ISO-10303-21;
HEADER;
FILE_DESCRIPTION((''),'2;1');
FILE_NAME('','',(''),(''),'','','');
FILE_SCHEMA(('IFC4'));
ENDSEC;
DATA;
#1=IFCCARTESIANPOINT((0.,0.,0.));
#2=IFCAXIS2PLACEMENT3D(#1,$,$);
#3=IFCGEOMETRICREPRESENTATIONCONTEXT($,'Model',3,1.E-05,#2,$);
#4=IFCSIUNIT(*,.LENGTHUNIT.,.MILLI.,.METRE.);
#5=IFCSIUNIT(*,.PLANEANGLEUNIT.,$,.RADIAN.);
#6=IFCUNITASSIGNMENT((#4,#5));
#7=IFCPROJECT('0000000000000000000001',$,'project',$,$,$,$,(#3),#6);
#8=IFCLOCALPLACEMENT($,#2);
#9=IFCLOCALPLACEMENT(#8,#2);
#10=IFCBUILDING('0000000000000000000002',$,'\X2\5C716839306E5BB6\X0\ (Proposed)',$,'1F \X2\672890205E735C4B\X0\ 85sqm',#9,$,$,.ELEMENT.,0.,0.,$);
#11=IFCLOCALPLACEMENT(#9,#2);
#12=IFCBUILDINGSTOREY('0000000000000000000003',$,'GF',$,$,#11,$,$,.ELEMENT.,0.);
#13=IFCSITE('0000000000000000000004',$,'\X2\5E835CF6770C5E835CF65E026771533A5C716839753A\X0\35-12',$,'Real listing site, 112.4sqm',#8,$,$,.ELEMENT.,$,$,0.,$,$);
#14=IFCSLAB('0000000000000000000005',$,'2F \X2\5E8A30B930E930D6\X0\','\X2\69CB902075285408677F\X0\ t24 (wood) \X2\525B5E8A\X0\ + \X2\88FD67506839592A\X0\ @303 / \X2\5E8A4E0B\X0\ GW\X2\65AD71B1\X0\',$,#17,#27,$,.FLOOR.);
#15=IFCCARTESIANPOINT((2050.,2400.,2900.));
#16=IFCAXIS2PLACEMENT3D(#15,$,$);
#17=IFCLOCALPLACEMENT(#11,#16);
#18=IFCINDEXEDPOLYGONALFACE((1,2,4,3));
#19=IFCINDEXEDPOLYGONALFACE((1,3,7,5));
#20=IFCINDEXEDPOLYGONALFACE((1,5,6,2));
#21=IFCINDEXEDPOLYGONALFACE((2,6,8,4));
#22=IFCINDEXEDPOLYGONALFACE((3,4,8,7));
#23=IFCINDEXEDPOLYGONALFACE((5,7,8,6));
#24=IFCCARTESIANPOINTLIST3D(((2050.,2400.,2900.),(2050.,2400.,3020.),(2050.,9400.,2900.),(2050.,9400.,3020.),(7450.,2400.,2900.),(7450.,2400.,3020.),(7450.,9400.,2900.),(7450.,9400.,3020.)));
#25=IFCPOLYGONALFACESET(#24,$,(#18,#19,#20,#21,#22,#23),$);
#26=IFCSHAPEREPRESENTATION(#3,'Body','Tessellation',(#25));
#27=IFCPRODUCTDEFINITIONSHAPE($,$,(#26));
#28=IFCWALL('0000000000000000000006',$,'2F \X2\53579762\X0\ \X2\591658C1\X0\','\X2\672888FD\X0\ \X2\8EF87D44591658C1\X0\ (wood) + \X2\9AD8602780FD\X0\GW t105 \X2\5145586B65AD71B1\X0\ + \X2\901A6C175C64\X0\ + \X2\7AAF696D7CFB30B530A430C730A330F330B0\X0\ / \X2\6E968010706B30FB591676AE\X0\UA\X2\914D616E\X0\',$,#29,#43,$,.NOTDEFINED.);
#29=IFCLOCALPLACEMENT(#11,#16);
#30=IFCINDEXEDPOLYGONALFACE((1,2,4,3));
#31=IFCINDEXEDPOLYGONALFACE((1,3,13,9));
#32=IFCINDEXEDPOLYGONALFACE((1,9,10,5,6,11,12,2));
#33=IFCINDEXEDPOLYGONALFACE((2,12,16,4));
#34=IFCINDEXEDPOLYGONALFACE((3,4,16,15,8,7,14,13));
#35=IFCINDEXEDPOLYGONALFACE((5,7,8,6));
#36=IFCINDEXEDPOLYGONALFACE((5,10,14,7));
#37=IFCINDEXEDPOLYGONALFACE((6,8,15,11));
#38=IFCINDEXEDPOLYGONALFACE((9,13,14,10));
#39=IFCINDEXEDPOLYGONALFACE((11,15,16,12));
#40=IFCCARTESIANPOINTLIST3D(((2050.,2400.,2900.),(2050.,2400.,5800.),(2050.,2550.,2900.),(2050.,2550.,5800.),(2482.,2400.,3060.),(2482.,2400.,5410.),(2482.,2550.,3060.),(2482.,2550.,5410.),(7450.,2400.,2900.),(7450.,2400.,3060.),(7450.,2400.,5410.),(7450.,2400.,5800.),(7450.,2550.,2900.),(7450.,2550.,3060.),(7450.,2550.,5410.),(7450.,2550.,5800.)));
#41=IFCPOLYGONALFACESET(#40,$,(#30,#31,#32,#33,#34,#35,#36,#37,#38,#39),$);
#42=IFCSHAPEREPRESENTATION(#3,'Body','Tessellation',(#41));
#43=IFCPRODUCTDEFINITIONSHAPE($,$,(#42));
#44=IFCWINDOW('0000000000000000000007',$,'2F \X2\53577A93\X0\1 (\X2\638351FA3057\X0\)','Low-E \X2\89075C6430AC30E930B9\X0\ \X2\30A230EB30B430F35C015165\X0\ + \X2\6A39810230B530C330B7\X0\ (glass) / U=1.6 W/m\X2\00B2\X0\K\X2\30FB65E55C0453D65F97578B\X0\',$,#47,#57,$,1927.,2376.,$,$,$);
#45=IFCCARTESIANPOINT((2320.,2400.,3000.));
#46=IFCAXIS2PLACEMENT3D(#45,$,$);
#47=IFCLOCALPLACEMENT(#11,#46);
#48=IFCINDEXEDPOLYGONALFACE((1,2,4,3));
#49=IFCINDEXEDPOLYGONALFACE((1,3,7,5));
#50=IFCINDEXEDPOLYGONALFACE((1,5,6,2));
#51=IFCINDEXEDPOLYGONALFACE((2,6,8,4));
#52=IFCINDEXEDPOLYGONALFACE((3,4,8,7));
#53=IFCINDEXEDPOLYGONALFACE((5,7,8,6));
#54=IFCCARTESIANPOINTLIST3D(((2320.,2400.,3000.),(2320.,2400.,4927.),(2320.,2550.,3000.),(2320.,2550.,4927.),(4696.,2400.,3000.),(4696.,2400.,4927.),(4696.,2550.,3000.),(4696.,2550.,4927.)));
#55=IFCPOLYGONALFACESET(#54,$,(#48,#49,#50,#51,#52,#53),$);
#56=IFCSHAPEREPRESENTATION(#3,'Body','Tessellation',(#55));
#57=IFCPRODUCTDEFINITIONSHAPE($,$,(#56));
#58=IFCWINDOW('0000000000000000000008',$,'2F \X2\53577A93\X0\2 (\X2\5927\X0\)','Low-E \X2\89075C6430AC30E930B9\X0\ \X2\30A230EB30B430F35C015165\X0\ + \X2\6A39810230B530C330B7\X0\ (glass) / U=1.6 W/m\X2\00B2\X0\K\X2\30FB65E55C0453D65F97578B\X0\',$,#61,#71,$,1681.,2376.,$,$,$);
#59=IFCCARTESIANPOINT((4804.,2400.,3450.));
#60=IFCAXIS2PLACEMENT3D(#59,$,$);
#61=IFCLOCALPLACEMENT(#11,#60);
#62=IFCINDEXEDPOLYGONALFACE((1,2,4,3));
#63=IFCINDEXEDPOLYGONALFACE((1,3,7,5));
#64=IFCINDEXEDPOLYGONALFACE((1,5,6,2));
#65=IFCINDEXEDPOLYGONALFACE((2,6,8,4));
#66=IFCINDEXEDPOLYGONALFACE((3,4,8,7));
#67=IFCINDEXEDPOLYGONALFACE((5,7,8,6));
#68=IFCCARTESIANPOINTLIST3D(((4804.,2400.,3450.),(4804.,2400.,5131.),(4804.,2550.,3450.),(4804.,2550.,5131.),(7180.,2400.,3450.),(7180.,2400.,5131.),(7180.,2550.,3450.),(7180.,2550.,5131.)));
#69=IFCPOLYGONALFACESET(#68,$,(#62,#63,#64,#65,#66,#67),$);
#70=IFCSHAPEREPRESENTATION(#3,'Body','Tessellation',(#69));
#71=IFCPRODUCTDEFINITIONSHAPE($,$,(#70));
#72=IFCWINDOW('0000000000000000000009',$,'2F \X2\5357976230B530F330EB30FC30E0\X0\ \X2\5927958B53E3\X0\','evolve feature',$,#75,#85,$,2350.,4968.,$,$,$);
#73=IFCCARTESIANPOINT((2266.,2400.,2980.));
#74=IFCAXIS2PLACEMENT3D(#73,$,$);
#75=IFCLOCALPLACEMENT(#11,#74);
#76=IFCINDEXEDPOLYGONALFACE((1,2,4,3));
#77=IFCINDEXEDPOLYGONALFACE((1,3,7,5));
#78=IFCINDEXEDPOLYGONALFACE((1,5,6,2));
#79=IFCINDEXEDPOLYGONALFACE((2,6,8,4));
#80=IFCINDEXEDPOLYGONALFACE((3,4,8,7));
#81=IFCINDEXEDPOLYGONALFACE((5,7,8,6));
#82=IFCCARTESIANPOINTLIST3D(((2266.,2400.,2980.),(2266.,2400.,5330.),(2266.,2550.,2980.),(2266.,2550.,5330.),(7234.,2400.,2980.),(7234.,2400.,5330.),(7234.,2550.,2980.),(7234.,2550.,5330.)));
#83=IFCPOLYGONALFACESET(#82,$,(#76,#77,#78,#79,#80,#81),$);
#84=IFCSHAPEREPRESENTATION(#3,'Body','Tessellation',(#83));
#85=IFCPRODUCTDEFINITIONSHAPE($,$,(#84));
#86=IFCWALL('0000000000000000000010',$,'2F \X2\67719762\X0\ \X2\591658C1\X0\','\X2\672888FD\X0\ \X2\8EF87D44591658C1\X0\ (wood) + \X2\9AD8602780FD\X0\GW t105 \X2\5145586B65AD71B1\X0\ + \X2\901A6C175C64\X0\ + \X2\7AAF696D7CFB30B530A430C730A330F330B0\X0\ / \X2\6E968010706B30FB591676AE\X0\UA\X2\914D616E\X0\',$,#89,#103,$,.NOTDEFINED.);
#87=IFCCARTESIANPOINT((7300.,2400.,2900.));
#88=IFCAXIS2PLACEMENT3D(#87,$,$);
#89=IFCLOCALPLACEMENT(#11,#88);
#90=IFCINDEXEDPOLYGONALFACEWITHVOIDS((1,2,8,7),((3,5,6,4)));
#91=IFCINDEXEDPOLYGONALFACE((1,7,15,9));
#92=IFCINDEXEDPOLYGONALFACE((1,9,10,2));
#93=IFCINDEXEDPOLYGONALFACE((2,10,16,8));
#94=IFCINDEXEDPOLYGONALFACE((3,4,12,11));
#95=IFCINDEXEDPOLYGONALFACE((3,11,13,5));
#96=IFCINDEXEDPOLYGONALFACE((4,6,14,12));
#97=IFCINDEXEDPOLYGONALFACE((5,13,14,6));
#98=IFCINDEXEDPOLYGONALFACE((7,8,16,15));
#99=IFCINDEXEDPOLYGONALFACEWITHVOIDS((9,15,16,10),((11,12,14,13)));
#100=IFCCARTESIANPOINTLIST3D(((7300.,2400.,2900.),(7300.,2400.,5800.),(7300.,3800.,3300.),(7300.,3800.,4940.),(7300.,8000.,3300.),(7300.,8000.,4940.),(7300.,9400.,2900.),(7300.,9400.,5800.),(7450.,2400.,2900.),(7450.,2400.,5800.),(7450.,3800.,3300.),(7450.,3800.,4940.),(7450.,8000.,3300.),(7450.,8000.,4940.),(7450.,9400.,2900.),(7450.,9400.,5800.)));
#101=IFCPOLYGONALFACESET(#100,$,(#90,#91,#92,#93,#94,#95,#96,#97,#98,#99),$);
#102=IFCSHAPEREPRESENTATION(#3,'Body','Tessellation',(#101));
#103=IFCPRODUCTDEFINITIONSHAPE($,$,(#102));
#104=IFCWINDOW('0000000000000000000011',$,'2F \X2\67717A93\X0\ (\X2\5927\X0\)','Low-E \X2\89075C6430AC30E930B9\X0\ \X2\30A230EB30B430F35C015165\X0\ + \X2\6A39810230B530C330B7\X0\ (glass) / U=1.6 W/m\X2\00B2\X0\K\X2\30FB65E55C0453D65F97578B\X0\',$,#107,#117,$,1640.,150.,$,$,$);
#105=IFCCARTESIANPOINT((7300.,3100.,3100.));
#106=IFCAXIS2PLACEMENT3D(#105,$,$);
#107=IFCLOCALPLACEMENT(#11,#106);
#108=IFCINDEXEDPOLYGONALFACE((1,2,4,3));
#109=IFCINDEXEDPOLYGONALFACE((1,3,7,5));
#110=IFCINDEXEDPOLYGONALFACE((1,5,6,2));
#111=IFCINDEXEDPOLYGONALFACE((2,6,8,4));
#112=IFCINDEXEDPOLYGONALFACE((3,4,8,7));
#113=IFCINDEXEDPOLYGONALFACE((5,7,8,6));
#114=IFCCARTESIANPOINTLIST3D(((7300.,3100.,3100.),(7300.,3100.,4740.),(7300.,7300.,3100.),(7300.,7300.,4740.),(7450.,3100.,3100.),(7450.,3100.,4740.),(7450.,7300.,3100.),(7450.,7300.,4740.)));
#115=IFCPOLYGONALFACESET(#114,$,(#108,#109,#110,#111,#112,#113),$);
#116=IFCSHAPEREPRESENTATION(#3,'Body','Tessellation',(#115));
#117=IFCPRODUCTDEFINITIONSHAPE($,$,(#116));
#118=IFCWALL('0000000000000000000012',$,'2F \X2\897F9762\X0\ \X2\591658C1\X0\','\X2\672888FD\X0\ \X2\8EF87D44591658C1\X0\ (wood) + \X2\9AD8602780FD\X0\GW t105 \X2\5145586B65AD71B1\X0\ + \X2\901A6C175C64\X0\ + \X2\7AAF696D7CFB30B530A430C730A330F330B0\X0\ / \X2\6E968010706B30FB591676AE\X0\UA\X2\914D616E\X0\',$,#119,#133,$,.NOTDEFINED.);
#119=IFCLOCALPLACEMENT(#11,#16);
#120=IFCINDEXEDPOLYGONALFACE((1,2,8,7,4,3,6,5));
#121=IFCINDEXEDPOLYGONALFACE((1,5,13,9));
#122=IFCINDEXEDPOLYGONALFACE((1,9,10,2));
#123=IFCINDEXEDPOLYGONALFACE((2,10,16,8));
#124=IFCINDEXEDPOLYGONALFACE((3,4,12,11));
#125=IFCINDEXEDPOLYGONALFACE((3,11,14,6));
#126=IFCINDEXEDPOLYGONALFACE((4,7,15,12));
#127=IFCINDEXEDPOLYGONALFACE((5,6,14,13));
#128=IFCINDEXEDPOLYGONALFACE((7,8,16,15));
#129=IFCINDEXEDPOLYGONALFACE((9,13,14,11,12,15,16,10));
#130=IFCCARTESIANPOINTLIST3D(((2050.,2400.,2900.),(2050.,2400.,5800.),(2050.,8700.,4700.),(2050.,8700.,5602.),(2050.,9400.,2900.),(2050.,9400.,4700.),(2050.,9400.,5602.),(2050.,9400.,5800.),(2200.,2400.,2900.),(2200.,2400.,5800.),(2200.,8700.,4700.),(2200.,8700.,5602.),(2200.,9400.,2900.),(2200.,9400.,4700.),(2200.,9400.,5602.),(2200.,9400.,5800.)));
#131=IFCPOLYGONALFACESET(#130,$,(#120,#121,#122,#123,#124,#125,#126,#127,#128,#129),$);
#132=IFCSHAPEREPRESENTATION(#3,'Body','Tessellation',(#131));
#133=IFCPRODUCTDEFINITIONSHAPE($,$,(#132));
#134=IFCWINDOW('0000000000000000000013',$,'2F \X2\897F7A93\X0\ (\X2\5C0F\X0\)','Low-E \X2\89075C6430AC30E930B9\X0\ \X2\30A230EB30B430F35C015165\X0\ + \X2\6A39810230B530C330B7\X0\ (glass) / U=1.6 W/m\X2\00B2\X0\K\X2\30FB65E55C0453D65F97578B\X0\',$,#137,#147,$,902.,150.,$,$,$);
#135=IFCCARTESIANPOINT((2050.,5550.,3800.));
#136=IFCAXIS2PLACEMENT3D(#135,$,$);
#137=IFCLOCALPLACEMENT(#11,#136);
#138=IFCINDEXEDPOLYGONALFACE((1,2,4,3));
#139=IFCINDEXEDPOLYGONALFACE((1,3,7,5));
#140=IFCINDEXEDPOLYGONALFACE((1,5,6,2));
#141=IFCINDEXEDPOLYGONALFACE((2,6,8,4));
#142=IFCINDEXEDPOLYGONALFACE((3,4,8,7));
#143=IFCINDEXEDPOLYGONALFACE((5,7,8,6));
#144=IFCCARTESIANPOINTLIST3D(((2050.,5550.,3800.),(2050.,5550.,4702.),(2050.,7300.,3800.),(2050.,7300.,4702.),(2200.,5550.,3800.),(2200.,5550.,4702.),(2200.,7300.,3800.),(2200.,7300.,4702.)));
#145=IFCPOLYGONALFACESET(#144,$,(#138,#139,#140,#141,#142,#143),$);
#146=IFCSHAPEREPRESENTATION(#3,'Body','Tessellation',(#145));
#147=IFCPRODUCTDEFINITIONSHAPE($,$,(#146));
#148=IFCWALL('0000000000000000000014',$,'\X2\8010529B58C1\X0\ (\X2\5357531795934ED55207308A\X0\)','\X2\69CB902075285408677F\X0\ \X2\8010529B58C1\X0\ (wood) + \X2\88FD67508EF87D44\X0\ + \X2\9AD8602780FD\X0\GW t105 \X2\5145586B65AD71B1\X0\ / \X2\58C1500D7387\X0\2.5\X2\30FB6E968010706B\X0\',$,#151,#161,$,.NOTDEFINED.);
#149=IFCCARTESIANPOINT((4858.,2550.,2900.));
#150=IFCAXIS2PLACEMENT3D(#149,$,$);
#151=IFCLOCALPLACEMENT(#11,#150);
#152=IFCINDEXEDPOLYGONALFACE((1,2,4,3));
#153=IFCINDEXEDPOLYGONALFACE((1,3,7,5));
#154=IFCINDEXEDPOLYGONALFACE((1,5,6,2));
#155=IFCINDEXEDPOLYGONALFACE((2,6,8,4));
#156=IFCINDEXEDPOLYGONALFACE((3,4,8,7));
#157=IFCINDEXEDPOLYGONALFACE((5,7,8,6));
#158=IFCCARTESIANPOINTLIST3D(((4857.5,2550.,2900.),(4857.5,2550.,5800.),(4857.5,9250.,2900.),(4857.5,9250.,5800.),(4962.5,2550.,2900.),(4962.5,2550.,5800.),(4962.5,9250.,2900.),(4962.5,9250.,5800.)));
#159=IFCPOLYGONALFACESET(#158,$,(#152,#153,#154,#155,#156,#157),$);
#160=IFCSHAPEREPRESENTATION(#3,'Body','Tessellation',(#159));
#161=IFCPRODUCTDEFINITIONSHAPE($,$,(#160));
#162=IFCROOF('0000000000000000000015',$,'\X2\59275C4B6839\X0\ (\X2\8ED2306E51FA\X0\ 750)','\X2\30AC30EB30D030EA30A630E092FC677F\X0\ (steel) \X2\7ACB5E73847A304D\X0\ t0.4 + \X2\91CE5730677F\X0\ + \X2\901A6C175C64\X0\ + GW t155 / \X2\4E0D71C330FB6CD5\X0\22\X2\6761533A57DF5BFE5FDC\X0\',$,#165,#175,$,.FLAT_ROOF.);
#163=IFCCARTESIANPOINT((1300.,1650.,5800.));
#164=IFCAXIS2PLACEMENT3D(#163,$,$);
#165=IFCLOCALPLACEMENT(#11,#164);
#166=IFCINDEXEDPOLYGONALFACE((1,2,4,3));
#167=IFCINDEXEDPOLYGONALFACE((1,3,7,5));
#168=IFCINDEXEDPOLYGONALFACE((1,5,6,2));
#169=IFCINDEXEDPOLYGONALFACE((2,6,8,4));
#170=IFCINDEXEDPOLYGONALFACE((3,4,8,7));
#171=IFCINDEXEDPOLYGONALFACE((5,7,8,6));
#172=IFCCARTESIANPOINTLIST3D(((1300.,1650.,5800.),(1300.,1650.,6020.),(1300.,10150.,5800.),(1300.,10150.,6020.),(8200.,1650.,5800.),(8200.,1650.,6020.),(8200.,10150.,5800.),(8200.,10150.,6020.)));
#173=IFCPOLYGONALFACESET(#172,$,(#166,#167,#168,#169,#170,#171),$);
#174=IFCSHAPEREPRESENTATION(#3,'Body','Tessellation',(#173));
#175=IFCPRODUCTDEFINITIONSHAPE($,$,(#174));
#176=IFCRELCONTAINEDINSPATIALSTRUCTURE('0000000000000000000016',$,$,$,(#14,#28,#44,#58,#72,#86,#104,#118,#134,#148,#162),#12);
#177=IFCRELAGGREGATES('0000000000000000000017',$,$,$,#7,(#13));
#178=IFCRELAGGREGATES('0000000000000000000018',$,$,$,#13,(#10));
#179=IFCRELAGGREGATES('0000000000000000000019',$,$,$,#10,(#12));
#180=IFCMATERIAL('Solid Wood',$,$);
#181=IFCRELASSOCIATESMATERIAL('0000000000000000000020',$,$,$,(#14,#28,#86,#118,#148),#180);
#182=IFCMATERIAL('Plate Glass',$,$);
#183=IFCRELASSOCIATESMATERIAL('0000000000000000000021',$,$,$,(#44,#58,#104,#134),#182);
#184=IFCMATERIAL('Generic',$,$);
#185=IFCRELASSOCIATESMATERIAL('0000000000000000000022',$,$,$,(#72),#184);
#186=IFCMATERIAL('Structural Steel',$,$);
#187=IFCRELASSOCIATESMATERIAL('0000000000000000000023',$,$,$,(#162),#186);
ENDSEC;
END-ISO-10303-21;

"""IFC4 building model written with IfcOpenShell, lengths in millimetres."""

from ifc_helpers import new_model, si_unit, frame, frame_2d, origin, place, context, project, spatial, rectangle, extrude, material, element, fill, save


model = new_model("IFC4")

# Units and contexts
model_context = context("Model", 3, precision=1e-05, world=origin())
ifc_project = project(units=[si_unit("LENGTHUNIT", "METRE", prefix="MILLI"), si_unit("PLANEANGLEUNIT", "RADIAN")], contexts=[model_context])

# Site, building, storey
site_placement = place(None, origin())
site = spatial("IfcSite", under=ifc_project, at=site_placement, Name="広島県広島市東区山根町35-12", ObjectType="Real listing site, 112.4sqm", CompositionType="ELEMENT", RefElevation=0.0)
building_placement = place(site_placement, origin())
building = spatial("IfcBuilding", under=site, at=building_placement, Name="山根の家 (Proposed)", ObjectType="1F 木造平屋 85sqm", CompositionType="ELEMENT", ElevationOfRefHeight=0.0, ElevationOfTerrain=0.0)
storey_placement = place(building_placement, origin())
storey = spatial("IfcBuildingStorey", under=building, at=storey_placement, Name="GF", CompositionType="ELEMENT", Elevation=0.0)

# Slab
ifc_material_1 = material(Name="Solid Wood")
slab_placement = place(storey_placement, frame((2050.0, 2400.0, 2900.0)))
element("IfcSlab", 1, at=slab_placement, inside=storey, material=ifc_material_1, Name="2F 床スラブ", Description="構造用合板 t24 (wood) 剛床 + 製材根太 @303 / 床下 GW断熱", PredefinedType="FLOOR", context=model_context, shape_type="SweptSolid", body=[
    extrude(rectangle(XDim=5400.0, YDim=7000.0, at=frame_2d((2700.0, 3500.0))), frame((2050.0, 2400.0, 2900.0)), (0.0, 0.0, 1.0), 120.0),
])

# Wall, openings, windows
wall_1_placement = place(storey_placement, frame((2050.0, 2400.0, 2900.0)))
wall_1 = element("IfcWall", 2, at=wall_1_placement, inside=storey, material=ifc_material_1, Name="2F 南面 外壁", Description="木製 軸組外壁 (wood) + 高性能GW t105 充填断熱 + 通気層 + 窯業系サイディング / 準耐火・外皮UA配慮", PredefinedType="NOTDEFINED", context=model_context, shape_type="SweptSolid", body=[
    extrude(rectangle(XDim=5400.0, YDim=150.0, at=frame_2d((2700.0, 75.0))), frame((2050.0, 2400.0, 2900.0)), (0.0, 0.0, 1.0), 2900.0),
])
opening_1_placement = place(storey_placement, frame((2320.0, 2400.0, 3000.0)))
opening_1 = element("IfcOpeningElement", 3, at=opening_1_placement, cuts=wall_1, PredefinedType="NOTDEFINED", context=model_context, shape_type="SweptSolid", body=[
    extrude(rectangle(XDim=2376.0, YDim=150.0, at=frame_2d((1188.0, 75.0))), frame((2320.0, 2400.0, 3000.0)), (0.0, 0.0, 1.0), 1927.0),
])
opening_2_placement = place(storey_placement, frame((4804.0, 2400.0, 3450.0)))
opening_2 = element("IfcOpeningElement", 4, at=opening_2_placement, cuts=wall_1, PredefinedType="NOTDEFINED", context=model_context, shape_type="SweptSolid", body=[
    extrude(rectangle(XDim=2376.0, YDim=150.0, at=frame_2d((1188.0, 75.0))), frame((4804.0, 2400.0, 3450.0)), (0.0, 0.0, 1.0), 1681.0),
])
opening_3_placement = place(storey_placement, frame((2266.0, 2400.0, 2980.0)))
opening_3 = element("IfcOpeningElement", 5, at=opening_3_placement, cuts=wall_1, PredefinedType="NOTDEFINED", context=model_context, shape_type="SweptSolid", body=[
    extrude(rectangle(XDim=4968.0, YDim=150.0, at=frame_2d((2484.0, 75.0))), frame((2266.0, 2400.0, 2980.0)), (0.0, 0.0, 1.0), 2350.0),
])
ifc_material_2 = material(Name="Plate Glass")
window_1_placement = place(storey_placement, frame((2320.0, 2400.0, 3000.0)))
window_1 = element("IfcWindow", 6, at=window_1_placement, inside=storey, material=ifc_material_2, Name="2F 南窓1 (掃出し)", Description="Low-E 複層ガラス アルゴン封入 + 樹脂サッシ (glass) / U=1.6 W/m²K・日射取得型", OverallHeight=1927.0, OverallWidth=2376.0, context=model_context, shape_type="SweptSolid", body=[
    extrude(rectangle(XDim=2376.0, YDim=150.0, at=frame_2d((1188.0, 75.0))), frame((2320.0, 2400.0, 3000.0)), (0.0, 0.0, 1.0), 1927.0),
])
fill(opening_1, window_1)
window_2_placement = place(storey_placement, frame((4804.0, 2400.0, 3450.0)))
window_2 = element("IfcWindow", 7, at=window_2_placement, inside=storey, material=ifc_material_2, Name="2F 南窓2 (大)", Description="Low-E 複層ガラス アルゴン封入 + 樹脂サッシ (glass) / U=1.6 W/m²K・日射取得型", OverallHeight=1681.0, OverallWidth=2376.0, context=model_context, shape_type="SweptSolid", body=[
    extrude(rectangle(XDim=2376.0, YDim=150.0, at=frame_2d((1188.0, 75.0))), frame((4804.0, 2400.0, 3450.0)), (0.0, 0.0, 1.0), 1681.0),
])
fill(opening_2, window_2)
ifc_material_3 = material(Name="Generic")
window_3_placement = place(storey_placement, frame((2266.0, 2400.0, 2980.0)))
window_3 = element("IfcWindow", 8, at=window_3_placement, inside=storey, material=ifc_material_3, Name="2F 南面サンルーム 大開口", Description="evolve feature", OverallHeight=2350.0, OverallWidth=4968.0, context=model_context, shape_type="SweptSolid", body=[
    extrude(rectangle(XDim=4968.0, YDim=150.0, at=frame_2d((2484.0, 75.0))), frame((2266.0, 2400.0, 2980.0)), (0.0, 0.0, 1.0), 2350.0),
])
fill(opening_3, window_3)

# Walls, openings, windows
wall_2_placement = place(storey_placement, frame((7300.0, 2400.0, 2900.0)))
wall_2 = element("IfcWall", 9, at=wall_2_placement, inside=storey, material=ifc_material_1, Name="2F 東面 外壁", Description="木製 軸組外壁 (wood) + 高性能GW t105 充填断熱 + 通気層 + 窯業系サイディング / 準耐火・外皮UA配慮", PredefinedType="NOTDEFINED", context=model_context, shape_type="SweptSolid", body=[
    extrude(rectangle(XDim=150.0, YDim=7000.0, at=frame_2d((75.0, 3500.0))), frame((7300.0, 2400.0, 2900.0)), (0.0, 0.0, 1.0), 2900.0),
])
opening_4_placement = place(storey_placement, frame((7300.0, 3100.0, 3100.0)))
opening_4 = element("IfcOpeningElement", 10, at=opening_4_placement, cuts=wall_2, PredefinedType="NOTDEFINED", context=model_context, shape_type="SweptSolid", body=[
    extrude(rectangle(XDim=150.0, YDim=4200.0, at=frame_2d((75.0, 2100.0))), frame((7300.0, 3100.0, 3100.0)), (0.0, 0.0, 1.0), 1640.0),
])
window_4_placement = place(storey_placement, frame((7300.0, 3100.0, 3100.0)))
window_4 = element("IfcWindow", 11, at=window_4_placement, inside=storey, material=ifc_material_2, Name="2F 東窓 (大)", Description="Low-E 複層ガラス アルゴン封入 + 樹脂サッシ (glass) / U=1.6 W/m²K・日射取得型", OverallHeight=1640.0, OverallWidth=150.0, context=model_context, shape_type="SweptSolid", body=[
    extrude(rectangle(XDim=150.0, YDim=4200.0, at=frame_2d((75.0, 2100.0))), frame((7300.0, 3100.0, 3100.0)), (0.0, 0.0, 1.0), 1640.0),
])
fill(opening_4, window_4)
wall_3_placement = place(storey_placement, frame((2050.0, 2400.0, 2900.0)))
wall_3 = element("IfcWall", 12, at=wall_3_placement, inside=storey, material=ifc_material_1, Name="2F 西面 外壁", Description="木製 軸組外壁 (wood) + 高性能GW t105 充填断熱 + 通気層 + 窯業系サイディング / 準耐火・外皮UA配慮", PredefinedType="NOTDEFINED", context=model_context, shape_type="SweptSolid", body=[
    extrude(rectangle(XDim=150.0, YDim=7000.0, at=frame_2d((75.0, 3500.0))), frame((2050.0, 2400.0, 2900.0)), (0.0, 0.0, 1.0), 2900.0),
])
opening_5_placement = place(storey_placement, frame((2050.0, 5550.0, 3800.0)))
opening_5 = element("IfcOpeningElement", 13, at=opening_5_placement, cuts=wall_3, PredefinedType="NOTDEFINED", context=model_context, shape_type="SweptSolid", body=[
    extrude(rectangle(XDim=150.0, YDim=1750.0, at=frame_2d((75.0, 875.0))), frame((2050.0, 5550.0, 3800.0)), (0.0, 0.0, 1.0), 902.0),
])
window_5_placement = place(storey_placement, frame((2050.0, 5550.0, 3800.0)))
window_5 = element("IfcWindow", 14, at=window_5_placement, inside=storey, material=ifc_material_2, Name="2F 西窓 (小)", Description="Low-E 複層ガラス アルゴン封入 + 樹脂サッシ (glass) / U=1.6 W/m²K・日射取得型", OverallHeight=902.0, OverallWidth=150.0, context=model_context, shape_type="SweptSolid", body=[
    extrude(rectangle(XDim=150.0, YDim=1750.0, at=frame_2d((75.0, 875.0))), frame((2050.0, 5550.0, 3800.0)), (0.0, 0.0, 1.0), 902.0),
])
fill(opening_5, window_5)

# Wall
wall_4_placement = place(storey_placement, frame((4858.0, 2550.0, 2900.0)))
element("IfcWall", 15, at=wall_4_placement, inside=storey, material=ifc_material_1, Name="耐力壁 (南北間仕切り)", Description="構造用合板 耐力壁 (wood) + 製材軸組 + 高性能GW t105 充填断熱 / 壁倍率2.5・準耐火", PredefinedType="NOTDEFINED", context=model_context, shape_type="SweptSolid", body=[
    extrude(rectangle(XDim=105.0, YDim=6700.0, at=frame_2d((52.0, 3350.0))), frame((4858.0, 2550.0, 2900.0)), (0.0, 0.0, 1.0), 2900.0),
])

# Roof
ifc_material_4 = material(Name="Structural Steel")
roof_placement = place(storey_placement, frame((1300.0, 1650.0, 5800.0)))
element("IfcRoof", 16, at=roof_placement, inside=storey, material=ifc_material_4, Name="大屋根 (軒の出 750)", Description="ガルバリウム鋼板 (steel) 立平葺き t0.4 + 野地板 + 通気層 + GW t155 / 不燃・法22条区域対応", PredefinedType="FLAT_ROOF", context=model_context, shape_type="SweptSolid", body=[
    extrude(rectangle(XDim=6900.0, YDim=8500.0, at=frame_2d((3450.0, 4250.0))), frame((1300.0, 1650.0, 5800.0)), (0.0, 0.0, 1.0), 220.0),
])

save(model, "model.ifc")
